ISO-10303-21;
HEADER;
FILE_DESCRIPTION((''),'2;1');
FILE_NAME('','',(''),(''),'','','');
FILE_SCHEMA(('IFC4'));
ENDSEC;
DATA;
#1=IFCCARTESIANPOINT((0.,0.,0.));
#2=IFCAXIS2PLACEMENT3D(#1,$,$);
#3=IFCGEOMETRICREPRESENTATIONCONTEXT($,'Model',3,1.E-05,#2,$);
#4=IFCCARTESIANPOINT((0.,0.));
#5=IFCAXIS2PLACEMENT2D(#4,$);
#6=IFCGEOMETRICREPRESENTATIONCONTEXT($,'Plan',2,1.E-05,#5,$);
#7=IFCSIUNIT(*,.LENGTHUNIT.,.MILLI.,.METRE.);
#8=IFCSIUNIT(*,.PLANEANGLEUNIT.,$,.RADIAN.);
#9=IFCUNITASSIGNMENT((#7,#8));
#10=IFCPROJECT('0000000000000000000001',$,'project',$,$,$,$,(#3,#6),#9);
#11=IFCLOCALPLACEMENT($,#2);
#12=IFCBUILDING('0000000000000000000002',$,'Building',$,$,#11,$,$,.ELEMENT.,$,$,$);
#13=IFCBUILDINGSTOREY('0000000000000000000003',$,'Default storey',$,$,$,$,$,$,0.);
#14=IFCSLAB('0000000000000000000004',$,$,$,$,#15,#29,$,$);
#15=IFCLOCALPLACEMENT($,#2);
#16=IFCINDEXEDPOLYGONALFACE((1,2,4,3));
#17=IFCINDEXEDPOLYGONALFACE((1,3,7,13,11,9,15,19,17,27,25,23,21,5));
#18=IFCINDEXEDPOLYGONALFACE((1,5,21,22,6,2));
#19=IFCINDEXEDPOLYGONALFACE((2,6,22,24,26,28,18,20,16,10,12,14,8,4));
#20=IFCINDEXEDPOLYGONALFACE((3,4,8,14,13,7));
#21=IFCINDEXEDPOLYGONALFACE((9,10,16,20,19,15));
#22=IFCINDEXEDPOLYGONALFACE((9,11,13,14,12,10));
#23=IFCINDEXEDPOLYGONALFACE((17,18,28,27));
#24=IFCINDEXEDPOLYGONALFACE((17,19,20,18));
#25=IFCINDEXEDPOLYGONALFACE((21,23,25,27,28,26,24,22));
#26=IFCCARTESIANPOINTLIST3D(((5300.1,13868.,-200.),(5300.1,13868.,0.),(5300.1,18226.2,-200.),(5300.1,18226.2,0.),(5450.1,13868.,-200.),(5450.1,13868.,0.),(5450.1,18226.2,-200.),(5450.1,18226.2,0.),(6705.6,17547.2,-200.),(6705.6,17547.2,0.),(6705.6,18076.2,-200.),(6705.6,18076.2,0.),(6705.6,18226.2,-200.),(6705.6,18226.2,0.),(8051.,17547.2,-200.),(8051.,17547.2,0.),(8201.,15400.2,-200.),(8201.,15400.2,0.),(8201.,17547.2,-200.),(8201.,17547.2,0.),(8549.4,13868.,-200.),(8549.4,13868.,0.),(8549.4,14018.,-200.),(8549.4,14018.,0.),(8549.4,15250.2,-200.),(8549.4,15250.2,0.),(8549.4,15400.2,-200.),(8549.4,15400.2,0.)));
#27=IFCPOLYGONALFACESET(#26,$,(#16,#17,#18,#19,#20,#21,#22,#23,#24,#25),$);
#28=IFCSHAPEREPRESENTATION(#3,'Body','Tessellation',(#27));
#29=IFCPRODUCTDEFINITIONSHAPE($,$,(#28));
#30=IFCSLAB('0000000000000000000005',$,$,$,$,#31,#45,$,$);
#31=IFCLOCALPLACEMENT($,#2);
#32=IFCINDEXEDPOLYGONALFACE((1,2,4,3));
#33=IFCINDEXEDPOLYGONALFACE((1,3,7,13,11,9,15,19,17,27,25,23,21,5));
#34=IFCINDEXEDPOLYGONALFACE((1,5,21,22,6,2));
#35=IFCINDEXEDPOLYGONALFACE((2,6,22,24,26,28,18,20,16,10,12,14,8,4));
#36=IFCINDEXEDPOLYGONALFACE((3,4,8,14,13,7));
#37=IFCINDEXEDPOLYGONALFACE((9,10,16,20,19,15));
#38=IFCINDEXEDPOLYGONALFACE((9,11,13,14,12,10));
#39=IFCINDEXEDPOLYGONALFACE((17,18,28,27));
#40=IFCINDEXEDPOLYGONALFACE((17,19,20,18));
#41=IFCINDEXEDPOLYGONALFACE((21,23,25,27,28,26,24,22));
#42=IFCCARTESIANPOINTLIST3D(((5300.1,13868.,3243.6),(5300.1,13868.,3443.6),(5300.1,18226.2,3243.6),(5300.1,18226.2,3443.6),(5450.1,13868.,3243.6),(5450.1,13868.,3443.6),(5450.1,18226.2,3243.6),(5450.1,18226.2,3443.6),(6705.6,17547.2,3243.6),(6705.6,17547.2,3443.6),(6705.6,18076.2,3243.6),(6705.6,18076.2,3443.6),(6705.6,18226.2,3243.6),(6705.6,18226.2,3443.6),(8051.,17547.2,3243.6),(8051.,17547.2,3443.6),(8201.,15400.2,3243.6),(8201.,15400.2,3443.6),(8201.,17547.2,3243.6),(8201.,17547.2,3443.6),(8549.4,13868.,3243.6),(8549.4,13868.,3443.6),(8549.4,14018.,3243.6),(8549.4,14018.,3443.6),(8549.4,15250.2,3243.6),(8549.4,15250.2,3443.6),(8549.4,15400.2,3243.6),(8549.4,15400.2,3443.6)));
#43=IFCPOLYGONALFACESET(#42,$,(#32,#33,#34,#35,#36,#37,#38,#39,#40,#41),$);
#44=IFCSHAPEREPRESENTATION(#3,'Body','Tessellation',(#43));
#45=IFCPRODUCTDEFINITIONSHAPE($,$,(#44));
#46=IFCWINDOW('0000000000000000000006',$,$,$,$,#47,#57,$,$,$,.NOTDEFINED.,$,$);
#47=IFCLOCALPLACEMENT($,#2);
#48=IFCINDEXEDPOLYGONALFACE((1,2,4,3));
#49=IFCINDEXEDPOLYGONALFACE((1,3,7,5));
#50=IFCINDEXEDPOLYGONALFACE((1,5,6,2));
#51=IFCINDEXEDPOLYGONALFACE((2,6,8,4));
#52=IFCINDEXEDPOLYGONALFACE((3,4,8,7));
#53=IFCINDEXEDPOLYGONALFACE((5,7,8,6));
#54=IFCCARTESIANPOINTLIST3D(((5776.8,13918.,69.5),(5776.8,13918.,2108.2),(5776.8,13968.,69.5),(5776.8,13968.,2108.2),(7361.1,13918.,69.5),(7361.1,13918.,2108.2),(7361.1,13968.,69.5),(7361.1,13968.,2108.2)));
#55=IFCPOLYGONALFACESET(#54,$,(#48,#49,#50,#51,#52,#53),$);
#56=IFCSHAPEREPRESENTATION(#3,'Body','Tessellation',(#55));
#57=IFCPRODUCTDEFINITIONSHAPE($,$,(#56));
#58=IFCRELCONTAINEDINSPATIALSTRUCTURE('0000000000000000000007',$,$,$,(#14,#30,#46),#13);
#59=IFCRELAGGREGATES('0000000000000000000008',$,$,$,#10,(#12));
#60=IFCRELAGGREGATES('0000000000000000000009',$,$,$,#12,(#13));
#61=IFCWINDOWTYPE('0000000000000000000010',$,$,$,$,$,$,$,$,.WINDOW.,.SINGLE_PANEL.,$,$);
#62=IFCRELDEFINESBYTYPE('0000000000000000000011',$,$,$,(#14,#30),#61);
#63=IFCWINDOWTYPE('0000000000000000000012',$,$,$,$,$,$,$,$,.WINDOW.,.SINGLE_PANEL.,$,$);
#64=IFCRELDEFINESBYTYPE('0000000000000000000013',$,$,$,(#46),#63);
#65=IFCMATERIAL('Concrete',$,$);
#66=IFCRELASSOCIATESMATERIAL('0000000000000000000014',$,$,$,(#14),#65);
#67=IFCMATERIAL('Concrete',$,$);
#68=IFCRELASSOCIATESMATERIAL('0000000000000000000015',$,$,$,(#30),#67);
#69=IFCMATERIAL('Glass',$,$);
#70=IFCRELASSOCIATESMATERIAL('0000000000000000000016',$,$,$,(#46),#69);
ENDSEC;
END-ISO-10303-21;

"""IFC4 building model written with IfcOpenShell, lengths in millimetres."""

from ifc_helpers import new_model, si_unit, frame, origin, origin_2d, place, context, project, spatial, polyline, rectangle, outline, extrude, material, type_object, element, save


model = new_model("IFC4")

# Units and contexts
model_context = context("Model", 3, precision=1e-05, world=origin())
plan_context = context("Plan", 2, precision=1e-05, world=origin_2d())
ifc_project = project(units=[si_unit("LENGTHUNIT", "METRE", prefix="MILLI"), si_unit("PLANEANGLEUNIT", "RADIAN")], contexts=[model_context, plan_context])

# Building, storey
placement = place(None, origin())
building = spatial("IfcBuilding", under=ifc_project, at=placement, Name="Building", CompositionType="ELEMENT")
storey = spatial("IfcBuildingStorey", under=building, Name="Default storey", Elevation=0.0)

# Slabs
ifc_material_1 = material(Name="Concrete")
window_type_1 = type_object("IfcWindowType", PartitioningType="SINGLE_PANEL", PredefinedType="WINDOW")
element("IfcSlab", 1, at=placement, inside=storey, type_object=window_type_1, material=ifc_material_1, context=model_context, shape_type="SweptSolid", body=[
    extrude(outline(polyline([(8201.0, 15400.2), (8201.0, 17547.2), (8051.0, 17547.2), (6705.6, 17547.2), (6705.6, 18076.2), (6705.6, 18226.2), (5450.1, 18226.2), (5300.1, 18226.2), (5300.1, 13868.0), (5450.1, 13868.0), (8549.4, 13868.0), (8549.4, 14018.0), (8549.4, 15250.2), (8549.4, 15400.2), (8201.0, 15400.2)])), frame((0.0, 0.0, -200.0), z_axis=(0.0, 0.0, 1000.0), x_axis=(1000.0, 0.0, 0.0)), (0.0, 0.0, 1.0), 200.0),
])
ifc_material_2 = material(Name="Concrete")
element("IfcSlab", 2, at=placement, inside=storey, type_object=window_type_1, material=ifc_material_2, context=model_context, shape_type="SweptSolid", body=[
    extrude(outline(polyline([(8201.0, 15400.2), (8201.0, 17547.2), (8051.0, 17547.2), (6705.6, 17547.2), (6705.6, 18076.2), (6705.6, 18226.2), (5450.1, 18226.2), (5300.1, 18226.2), (5300.1, 13868.0), (5450.1, 13868.0), (8549.4, 13868.0), (8549.4, 14018.0), (8549.4, 15250.2), (8549.4, 15400.2), (8201.0, 15400.2)])), frame((0.0, 0.0, 3243.6), z_axis=(0.0, 0.0, 1000.0), x_axis=(1000.0, 0.0, 0.0)), (0.0, 0.0, 1.0), 200.0),
])

# Window
ifc_material_3 = material(Name="Glass")
window_type_2 = type_object("IfcWindowType", PartitioningType="SINGLE_PANEL", PredefinedType="WINDOW")
element("IfcWindow", 3, at=placement, inside=storey, type_object=window_type_2, material=ifc_material_3, PredefinedType="NOTDEFINED", context=model_context, shape_type="CSG", body=[
    extrude(rectangle(XDim=1584.2, YDim=50.0, at=origin_2d()), frame((6568.9, 13943.0, 69.5), z_axis=(0.0, 0.0, 1000.0), x_axis=(1584.249973, 0.0, 0.0)), (0.0, 0.0, 1.0), 2038.7),
])

save(model, "model.ifc")
